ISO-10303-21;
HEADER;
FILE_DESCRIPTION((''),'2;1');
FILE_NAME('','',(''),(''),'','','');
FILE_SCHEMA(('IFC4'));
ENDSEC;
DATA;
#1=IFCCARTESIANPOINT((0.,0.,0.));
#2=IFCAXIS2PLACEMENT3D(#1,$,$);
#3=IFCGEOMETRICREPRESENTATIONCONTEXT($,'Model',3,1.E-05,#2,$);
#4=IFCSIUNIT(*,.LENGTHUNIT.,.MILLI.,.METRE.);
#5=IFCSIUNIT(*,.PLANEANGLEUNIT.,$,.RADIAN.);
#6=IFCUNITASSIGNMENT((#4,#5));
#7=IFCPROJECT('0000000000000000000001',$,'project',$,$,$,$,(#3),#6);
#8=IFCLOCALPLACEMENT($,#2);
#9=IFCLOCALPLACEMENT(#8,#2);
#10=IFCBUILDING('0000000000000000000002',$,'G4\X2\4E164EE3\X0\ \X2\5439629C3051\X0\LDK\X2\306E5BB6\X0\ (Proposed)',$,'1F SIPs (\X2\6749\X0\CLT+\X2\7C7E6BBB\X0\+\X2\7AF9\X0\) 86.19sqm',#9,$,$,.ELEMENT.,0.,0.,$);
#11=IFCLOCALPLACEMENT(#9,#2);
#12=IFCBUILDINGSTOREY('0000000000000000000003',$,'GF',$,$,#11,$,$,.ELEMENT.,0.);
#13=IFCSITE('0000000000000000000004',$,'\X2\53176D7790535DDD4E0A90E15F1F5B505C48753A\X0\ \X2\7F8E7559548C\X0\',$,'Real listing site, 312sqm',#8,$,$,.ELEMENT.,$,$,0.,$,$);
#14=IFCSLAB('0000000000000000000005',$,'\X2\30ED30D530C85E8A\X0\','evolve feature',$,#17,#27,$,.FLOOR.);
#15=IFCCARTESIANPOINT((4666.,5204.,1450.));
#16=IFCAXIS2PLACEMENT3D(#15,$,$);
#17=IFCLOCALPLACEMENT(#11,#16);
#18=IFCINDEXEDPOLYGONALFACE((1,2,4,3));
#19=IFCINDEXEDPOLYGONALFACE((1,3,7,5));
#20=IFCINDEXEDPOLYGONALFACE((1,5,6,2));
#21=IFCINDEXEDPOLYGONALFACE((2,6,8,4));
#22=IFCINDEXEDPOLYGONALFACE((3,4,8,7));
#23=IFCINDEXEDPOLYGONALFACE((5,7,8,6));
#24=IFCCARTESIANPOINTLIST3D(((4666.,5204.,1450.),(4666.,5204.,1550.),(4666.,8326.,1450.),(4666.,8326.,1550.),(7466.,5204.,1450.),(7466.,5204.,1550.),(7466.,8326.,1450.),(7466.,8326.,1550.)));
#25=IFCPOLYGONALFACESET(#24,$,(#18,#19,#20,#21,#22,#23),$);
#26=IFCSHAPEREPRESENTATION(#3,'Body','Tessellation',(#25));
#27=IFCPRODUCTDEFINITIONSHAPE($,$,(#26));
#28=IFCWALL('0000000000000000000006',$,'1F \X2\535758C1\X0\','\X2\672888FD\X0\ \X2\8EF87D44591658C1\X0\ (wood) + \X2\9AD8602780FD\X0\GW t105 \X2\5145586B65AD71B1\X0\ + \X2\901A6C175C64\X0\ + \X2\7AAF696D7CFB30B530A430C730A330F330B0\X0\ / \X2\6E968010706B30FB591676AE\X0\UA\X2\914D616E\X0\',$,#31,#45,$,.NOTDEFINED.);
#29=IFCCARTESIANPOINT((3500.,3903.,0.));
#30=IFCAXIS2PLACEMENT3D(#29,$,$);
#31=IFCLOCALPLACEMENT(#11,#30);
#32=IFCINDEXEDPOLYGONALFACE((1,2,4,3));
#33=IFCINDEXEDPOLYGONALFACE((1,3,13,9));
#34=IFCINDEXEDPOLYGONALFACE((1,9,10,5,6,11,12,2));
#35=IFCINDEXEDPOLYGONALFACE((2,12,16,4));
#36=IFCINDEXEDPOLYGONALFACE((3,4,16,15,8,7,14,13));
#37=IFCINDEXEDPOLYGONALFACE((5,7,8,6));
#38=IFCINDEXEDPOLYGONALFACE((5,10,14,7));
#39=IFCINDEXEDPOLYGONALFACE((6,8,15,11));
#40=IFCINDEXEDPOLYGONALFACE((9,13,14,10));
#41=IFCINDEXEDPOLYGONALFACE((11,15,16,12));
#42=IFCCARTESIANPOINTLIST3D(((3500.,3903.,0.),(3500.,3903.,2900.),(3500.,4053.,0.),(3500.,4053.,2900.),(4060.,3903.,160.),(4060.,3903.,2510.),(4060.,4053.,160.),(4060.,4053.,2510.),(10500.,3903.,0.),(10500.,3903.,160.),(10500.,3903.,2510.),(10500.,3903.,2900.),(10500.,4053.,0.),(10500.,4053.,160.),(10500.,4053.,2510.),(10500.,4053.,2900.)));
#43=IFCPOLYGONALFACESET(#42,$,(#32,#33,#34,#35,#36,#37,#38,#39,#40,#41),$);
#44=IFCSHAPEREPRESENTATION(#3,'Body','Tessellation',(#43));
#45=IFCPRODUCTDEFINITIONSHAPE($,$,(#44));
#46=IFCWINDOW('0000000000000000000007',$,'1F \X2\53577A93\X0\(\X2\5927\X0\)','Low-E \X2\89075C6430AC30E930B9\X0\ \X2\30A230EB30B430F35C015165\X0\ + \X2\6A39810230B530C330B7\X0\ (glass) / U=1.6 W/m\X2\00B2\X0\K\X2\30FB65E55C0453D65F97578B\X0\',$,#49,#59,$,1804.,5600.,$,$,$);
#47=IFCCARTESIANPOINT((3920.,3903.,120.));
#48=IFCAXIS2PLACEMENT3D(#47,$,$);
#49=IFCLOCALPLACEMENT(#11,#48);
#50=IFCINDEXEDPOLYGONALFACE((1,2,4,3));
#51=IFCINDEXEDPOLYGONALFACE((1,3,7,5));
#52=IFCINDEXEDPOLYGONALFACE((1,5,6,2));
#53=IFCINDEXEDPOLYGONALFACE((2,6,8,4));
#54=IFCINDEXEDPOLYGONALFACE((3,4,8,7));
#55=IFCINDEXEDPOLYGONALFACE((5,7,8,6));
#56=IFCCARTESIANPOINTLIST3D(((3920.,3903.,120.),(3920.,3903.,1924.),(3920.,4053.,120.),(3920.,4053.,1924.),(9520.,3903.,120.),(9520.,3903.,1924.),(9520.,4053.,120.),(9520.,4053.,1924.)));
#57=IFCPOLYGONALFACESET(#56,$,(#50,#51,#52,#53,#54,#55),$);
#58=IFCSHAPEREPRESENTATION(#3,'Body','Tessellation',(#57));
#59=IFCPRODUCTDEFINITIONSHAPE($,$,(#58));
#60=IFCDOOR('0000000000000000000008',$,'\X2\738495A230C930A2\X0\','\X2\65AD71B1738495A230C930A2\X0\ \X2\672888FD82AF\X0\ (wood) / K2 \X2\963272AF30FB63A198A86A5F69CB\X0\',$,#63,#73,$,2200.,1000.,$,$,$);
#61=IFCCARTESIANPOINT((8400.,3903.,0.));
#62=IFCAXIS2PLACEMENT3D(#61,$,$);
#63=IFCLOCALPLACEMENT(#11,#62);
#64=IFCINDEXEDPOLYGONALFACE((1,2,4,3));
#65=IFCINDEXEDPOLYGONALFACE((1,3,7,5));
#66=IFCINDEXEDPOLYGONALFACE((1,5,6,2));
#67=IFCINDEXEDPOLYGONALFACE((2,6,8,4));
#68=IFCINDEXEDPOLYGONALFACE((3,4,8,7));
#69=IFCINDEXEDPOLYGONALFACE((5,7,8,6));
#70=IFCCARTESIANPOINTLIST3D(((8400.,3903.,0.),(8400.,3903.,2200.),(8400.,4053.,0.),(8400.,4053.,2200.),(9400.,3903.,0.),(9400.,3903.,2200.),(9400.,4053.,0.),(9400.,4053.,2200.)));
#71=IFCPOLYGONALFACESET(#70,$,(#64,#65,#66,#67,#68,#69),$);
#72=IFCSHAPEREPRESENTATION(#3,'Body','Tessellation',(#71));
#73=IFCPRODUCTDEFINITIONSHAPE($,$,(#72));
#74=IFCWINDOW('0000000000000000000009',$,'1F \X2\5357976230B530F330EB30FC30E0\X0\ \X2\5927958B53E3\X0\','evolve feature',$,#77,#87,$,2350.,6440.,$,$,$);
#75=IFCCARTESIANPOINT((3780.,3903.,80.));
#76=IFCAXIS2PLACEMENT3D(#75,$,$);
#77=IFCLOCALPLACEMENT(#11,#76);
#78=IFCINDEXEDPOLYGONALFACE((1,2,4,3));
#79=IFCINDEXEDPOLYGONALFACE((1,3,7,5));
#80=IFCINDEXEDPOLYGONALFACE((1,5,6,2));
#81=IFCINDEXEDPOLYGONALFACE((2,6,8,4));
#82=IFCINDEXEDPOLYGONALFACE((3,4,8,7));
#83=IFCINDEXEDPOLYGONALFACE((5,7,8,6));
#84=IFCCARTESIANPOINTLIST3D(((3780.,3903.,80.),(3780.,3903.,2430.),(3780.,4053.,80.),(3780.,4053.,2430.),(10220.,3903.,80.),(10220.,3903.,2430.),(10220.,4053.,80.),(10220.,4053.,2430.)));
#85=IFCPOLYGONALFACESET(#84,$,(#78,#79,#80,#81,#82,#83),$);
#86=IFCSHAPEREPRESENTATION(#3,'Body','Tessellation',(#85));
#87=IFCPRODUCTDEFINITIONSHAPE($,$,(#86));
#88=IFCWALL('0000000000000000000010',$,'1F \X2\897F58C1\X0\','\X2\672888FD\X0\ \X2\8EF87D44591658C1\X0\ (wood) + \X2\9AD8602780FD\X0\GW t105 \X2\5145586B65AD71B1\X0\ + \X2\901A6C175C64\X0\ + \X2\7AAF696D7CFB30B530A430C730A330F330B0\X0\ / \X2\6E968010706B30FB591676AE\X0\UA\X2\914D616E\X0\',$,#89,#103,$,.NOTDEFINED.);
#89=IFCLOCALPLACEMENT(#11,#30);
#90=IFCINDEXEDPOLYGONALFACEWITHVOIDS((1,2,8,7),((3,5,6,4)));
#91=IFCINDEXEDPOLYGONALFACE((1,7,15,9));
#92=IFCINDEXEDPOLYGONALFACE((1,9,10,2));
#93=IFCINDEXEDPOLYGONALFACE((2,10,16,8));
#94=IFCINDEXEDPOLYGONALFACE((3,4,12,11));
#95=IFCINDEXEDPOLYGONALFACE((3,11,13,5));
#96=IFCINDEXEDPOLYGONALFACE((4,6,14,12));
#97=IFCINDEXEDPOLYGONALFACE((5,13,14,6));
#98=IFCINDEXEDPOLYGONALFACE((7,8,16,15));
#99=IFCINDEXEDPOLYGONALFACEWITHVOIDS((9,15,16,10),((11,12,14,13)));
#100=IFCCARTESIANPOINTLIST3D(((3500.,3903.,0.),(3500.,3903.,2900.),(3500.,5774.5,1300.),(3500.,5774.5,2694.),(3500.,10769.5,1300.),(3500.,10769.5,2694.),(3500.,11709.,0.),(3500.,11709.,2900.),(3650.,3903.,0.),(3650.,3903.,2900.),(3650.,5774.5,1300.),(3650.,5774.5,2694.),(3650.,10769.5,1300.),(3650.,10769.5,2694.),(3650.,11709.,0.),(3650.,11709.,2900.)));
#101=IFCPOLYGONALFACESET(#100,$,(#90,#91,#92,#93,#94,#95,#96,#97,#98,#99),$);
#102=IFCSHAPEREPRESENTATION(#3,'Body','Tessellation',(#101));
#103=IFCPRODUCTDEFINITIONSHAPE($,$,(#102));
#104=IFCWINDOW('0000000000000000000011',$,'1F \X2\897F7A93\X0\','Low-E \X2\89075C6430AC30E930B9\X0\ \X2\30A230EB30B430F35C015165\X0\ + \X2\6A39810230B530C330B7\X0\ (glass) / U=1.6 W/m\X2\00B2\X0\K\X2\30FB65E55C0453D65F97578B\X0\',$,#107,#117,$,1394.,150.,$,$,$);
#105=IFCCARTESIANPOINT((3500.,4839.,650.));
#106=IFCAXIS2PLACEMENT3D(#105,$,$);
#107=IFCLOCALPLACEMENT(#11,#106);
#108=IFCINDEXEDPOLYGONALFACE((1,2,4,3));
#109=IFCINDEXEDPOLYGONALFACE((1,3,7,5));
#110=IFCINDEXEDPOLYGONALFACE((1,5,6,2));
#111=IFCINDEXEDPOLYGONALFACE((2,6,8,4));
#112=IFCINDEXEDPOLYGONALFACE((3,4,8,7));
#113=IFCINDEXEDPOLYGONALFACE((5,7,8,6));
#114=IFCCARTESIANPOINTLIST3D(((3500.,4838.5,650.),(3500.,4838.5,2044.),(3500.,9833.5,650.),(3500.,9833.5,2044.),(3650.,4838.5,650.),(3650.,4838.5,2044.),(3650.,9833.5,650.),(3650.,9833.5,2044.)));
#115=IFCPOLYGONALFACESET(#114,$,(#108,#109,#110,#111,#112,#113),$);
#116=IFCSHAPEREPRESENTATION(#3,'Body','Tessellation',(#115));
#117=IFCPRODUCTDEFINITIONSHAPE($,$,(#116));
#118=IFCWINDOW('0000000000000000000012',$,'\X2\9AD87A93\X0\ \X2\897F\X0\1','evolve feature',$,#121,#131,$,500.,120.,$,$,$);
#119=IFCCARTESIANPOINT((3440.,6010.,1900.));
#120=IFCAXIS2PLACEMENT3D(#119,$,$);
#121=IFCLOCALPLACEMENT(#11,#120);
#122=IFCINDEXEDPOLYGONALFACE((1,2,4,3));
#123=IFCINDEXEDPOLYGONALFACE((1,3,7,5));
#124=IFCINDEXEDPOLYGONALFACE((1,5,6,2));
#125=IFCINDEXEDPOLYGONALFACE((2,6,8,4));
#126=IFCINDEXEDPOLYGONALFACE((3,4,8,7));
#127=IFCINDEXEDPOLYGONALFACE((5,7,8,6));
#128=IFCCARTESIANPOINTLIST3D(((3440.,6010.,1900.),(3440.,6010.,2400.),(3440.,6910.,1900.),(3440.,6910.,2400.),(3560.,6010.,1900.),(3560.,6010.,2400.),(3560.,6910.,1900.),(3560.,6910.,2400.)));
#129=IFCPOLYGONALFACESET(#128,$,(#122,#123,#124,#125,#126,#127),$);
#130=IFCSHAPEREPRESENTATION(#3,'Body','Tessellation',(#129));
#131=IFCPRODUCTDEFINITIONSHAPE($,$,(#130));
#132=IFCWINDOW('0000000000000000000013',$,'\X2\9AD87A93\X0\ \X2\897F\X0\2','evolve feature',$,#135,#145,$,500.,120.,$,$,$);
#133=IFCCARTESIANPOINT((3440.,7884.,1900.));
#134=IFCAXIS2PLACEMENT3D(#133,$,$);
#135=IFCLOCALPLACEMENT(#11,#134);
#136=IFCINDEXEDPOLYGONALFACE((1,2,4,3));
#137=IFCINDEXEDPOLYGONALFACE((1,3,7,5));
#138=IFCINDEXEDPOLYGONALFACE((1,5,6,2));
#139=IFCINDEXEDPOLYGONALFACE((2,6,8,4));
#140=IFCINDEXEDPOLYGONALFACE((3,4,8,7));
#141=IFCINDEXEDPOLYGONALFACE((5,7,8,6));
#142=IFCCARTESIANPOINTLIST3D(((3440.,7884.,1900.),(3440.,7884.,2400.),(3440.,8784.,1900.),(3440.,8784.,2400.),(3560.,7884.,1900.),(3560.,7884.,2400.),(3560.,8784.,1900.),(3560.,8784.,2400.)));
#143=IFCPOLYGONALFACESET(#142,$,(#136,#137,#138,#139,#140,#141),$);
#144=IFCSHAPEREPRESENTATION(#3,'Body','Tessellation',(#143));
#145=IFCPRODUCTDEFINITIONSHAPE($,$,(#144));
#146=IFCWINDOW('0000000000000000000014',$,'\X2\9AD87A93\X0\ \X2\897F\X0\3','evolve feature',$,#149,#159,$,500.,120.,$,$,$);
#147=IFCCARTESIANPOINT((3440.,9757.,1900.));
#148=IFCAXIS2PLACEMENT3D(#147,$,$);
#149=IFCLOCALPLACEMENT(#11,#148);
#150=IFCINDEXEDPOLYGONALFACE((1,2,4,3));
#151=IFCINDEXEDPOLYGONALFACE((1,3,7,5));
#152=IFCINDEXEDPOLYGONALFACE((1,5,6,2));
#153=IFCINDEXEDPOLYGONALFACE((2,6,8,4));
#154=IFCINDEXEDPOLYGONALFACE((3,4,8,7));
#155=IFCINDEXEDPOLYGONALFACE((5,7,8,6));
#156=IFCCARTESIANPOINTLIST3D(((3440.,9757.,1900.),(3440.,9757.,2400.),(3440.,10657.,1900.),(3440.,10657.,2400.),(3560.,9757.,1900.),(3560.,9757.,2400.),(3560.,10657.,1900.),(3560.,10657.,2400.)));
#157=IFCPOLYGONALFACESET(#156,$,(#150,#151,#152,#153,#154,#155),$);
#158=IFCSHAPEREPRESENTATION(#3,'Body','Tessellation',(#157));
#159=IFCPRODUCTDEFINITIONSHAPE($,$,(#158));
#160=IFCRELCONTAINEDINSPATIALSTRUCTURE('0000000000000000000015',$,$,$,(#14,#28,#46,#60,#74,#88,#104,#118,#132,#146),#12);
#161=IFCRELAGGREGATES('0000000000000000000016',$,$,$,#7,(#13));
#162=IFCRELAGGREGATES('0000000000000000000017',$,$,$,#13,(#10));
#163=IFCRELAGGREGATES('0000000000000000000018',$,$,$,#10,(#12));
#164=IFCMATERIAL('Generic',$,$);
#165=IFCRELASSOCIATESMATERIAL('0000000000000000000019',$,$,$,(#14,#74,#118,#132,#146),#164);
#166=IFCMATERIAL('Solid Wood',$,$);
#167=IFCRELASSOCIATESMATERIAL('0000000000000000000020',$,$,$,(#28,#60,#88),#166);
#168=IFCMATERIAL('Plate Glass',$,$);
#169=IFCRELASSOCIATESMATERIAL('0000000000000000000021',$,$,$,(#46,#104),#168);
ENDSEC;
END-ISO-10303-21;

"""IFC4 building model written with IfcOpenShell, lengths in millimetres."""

from ifc_helpers import new_model, si_unit, frame, frame_2d, origin, place, context, project, spatial, rectangle, extrude, material, element, fill, save


model = new_model("IFC4")

# Units and contexts
model_context = context("Model", 3, precision=1e-05, world=origin())
ifc_project = project(units=[si_unit("LENGTHUNIT", "METRE", prefix="MILLI"), si_unit("PLANEANGLEUNIT", "RADIAN")], contexts=[model_context])

# Site, building, storey
site_placement = place(None, origin())
site = spatial("IfcSite", under=ifc_project, at=site_placement, Name="北海道川上郡弟子屈町 美留和", ObjectType="Real listing site, 312sqm", CompositionType="ELEMENT", RefElevation=0.0)
building_placement = place(site_placement, origin())
building = spatial("IfcBuilding", under=site, at=building_placement, Name="G4世代 吹抜けLDKの家 (Proposed)", ObjectType="1F SIPs (杉CLT+籾殻+竹) 86.19sqm", CompositionType="ELEMENT", ElevationOfRefHeight=0.0, ElevationOfTerrain=0.0)
storey_placement = place(building_placement, origin())
storey = spatial("IfcBuildingStorey", under=building, at=storey_placement, Name="GF", CompositionType="ELEMENT", Elevation=0.0)

# Slab
ifc_material_1 = material(Name="Solid Wood")
ifc_material_2 = material(Name="Generic")
slab_1_placement = place(storey_placement, frame((4666.0, 5204.0, 1450.0)))
element("IfcSlab", 1, at=slab_1_placement, inside=storey, material=ifc_material_2, Name="ロフト床", Description="evolve feature", PredefinedType="FLOOR", context=model_context, shape_type="SweptSolid", body=[
    extrude(rectangle(XDim=2800.0, YDim=3122.0, at=frame_2d((1400.0, 1561.0))), frame((4666.0, 5204.0, 1450.0)), (0.0, 0.0, 1.0), 100.0),
])

# Wall, openings, windows, door
wall_1_placement = place(storey_placement, frame((3500.0, 3903.0, 0.0)))
wall_1 = element("IfcWall", 2, at=wall_1_placement, inside=storey, material=ifc_material_1, Name="1F 南壁", Description="木製 軸組外壁 (wood) + 高性能GW t105 充填断熱 + 通気層 + 窯業系サイディング / 準耐火・外皮UA配慮", PredefinedType="NOTDEFINED", context=model_context, shape_type="SweptSolid", body=[
    extrude(rectangle(XDim=7000.0, YDim=150.0, at=frame_2d((3500.0, 75.0))), frame((3500.0, 3903.0, 0.0)), (0.0, 0.0, 1.0), 2900.0),
])
opening_1_placement = place(storey_placement, frame((3920.0, 3903.0, 120.0)))
opening_1 = element("IfcOpeningElement", 3, at=opening_1_placement, cuts=wall_1, PredefinedType="NOTDEFINED", context=model_context, shape_type="SweptSolid", body=[
    extrude(rectangle(XDim=5600.0, YDim=150.0, at=frame_2d((2800.0, 75.0))), frame((3920.0, 3903.0, 120.0)), (0.0, 0.0, 1.0), 1804.0),
])
opening_2_placement = place(storey_placement, frame((8400.0, 3903.0, 0.0)))
opening_2 = element("IfcOpeningElement", 4, at=opening_2_placement, cuts=wall_1, PredefinedType="NOTDEFINED", context=model_context, shape_type="SweptSolid", body=[
    extrude(rectangle(XDim=1000.0, YDim=150.0, at=frame_2d((500.0, 75.0))), frame((8400.0, 3903.0, 0.0)), (0.0, 0.0, 1.0), 2200.0),
])
opening_3_placement = place(storey_placement, frame((3780.0, 3903.0, 80.0)))
opening_3 = element("IfcOpeningElement", 5, at=opening_3_placement, cuts=wall_1, PredefinedType="NOTDEFINED", context=model_context, shape_type="SweptSolid", body=[
    extrude(rectangle(XDim=6440.0, YDim=150.0, at=frame_2d((3220.0, 75.0))), frame((3780.0, 3903.0, 80.0)), (0.0, 0.0, 1.0), 2350.0),
])
ifc_material_3 = material(Name="Plate Glass")
window_1_placement = place(storey_placement, frame((3920.0, 3903.0, 120.0)))
window_1 = element("IfcWindow", 6, at=window_1_placement, inside=storey, material=ifc_material_3, Name="1F 南窓(大)", Description="Low-E 複層ガラス アルゴン封入 + 樹脂サッシ (glass) / U=1.6 W/m²K・日射取得型", OverallHeight=1804.0, OverallWidth=5600.0, context=model_context, shape_type="SweptSolid", body=[
    extrude(rectangle(XDim=5600.0, YDim=150.0, at=frame_2d((2800.0, 75.0))), frame((3920.0, 3903.0, 120.0)), (0.0, 0.0, 1.0), 1804.0),
])
fill(opening_1, window_1)
door_placement = place(storey_placement, frame((8400.0, 3903.0, 0.0)))
door = element("IfcDoor", 7, at=door_placement, inside=storey, material=ifc_material_1, Name="玄関ドア", Description="断熱玄関ドア 木製芯 (wood) / K2 防犯・採風機構", OverallHeight=2200.0, OverallWidth=1000.0, context=model_context, shape_type="SweptSolid", body=[
    extrude(rectangle(XDim=1000.0, YDim=150.0, at=frame_2d((500.0, 75.0))), frame((8400.0, 3903.0, 0.0)), (0.0, 0.0, 1.0), 2200.0),
])
fill(opening_2, door)
window_2_placement = place(storey_placement, frame((3780.0, 3903.0, 80.0)))
window_2 = element("IfcWindow", 8, at=window_2_placement, inside=storey, material=ifc_material_2, Name="1F 南面サンルーム 大開口", Description="evolve feature", OverallHeight=2350.0, OverallWidth=6440.0, context=model_context, shape_type="SweptSolid", body=[
    extrude(rectangle(XDim=6440.0, YDim=150.0, at=frame_2d((3220.0, 75.0))), frame((3780.0, 3903.0, 80.0)), (0.0, 0.0, 1.0), 2350.0),
])
fill(opening_3, window_2)

# Wall, openings, windows
wall_2_placement = place(storey_placement, frame((3500.0, 3903.0, 0.0)))
wall_2 = element("IfcWall", 9, at=wall_2_placement, inside=storey, material=ifc_material_1, Name="1F 西壁", Description="木製 軸組外壁 (wood) + 高性能GW t105 充填断熱 + 通気層 + 窯業系サイディング / 準耐火・外皮UA配慮", PredefinedType="NOTDEFINED", context=model_context, shape_type="SweptSolid", body=[
    extrude(rectangle(XDim=150.0, YDim=7806.0, at=frame_2d((75.0, 3903.0))), frame((3500.0, 3903.0, 0.0)), (0.0, 0.0, 1.0), 2900.0),
])
opening_4_placement = place(storey_placement, frame((3500.0, 4839.0, 650.0)))
opening_4 = element("IfcOpeningElement", 10, at=opening_4_placement, cuts=wall_2, PredefinedType="NOTDEFINED", context=model_context, shape_type="SweptSolid", body=[
    extrude(rectangle(XDim=150.0, YDim=4995.0, at=frame_2d((75.0, 2497.0))), frame((3500.0, 4839.0, 650.0)), (0.0, 0.0, 1.0), 1394.0),
])
opening_5_placement = place(storey_placement, frame((3440.0, 6010.0, 1900.0)))
opening_5 = element("IfcOpeningElement", 11, at=opening_5_placement, cuts=wall_2, PredefinedType="NOTDEFINED", context=model_context, shape_type="SweptSolid", body=[
    extrude(rectangle(XDim=120.0, YDim=900.0, at=frame_2d((60.0, 450.0))), frame((3440.0, 6010.0, 1900.0)), (0.0, 0.0, 1.0), 500.0),
])
opening_6_placement = place(storey_placement, frame((3440.0, 7884.0, 1900.0)))
opening_6 = element("IfcOpeningElement", 12, at=opening_6_placement, cuts=wall_2, PredefinedType="NOTDEFINED", context=model_context, shape_type="SweptSolid", body=[
    extrude(rectangle(XDim=120.0, YDim=900.0, at=frame_2d((60.0, 450.0))), frame((3440.0, 7884.0, 1900.0)), (0.0, 0.0, 1.0), 500.0),
])
opening_7_placement = place(storey_placement, frame((3440.0, 9757.0, 1900.0)))
opening_7 = element("IfcOpeningElement", 13, at=opening_7_placement, cuts=wall_2, PredefinedType="NOTDEFINED", context=model_context, shape_type="SweptSolid", body=[
    extrude(rectangle(XDim=120.0, YDim=900.0, at=frame_2d((60.0, 450.0))), frame((3440.0, 9757.0, 1900.0)), (0.0, 0.0, 1.0), 500.0),
])
window_3_placement = place(storey_placement, frame((3500.0, 4839.0, 650.0)))
window_3 = element("IfcWindow", 14, at=window_3_placement, inside=storey, material=ifc_material_3, Name="1F 西窓", Description="Low-E 複層ガラス アルゴン封入 + 樹脂サッシ (glass) / U=1.6 W/m²K・日射取得型", OverallHeight=1394.0, OverallWidth=150.0, context=model_context, shape_type="SweptSolid", body=[
    extrude(rectangle(XDim=150.0, YDim=4995.0, at=frame_2d((75.0, 2497.0))), frame((3500.0, 4839.0, 650.0)), (0.0, 0.0, 1.0), 1394.0),
])
fill(opening_4, window_3)
window_4_placement = place(storey_placement, frame((3440.0, 6010.0, 1900.0)))
window_4 = element("IfcWindow", 15, at=window_4_placement, inside=storey, material=ifc_material_2, Name="高窓 西1", Description="evolve feature", OverallHeight=500.0, OverallWidth=120.0, context=model_context, shape_type="SweptSolid", body=[
    extrude(rectangle(XDim=120.0, YDim=900.0, at=frame_2d((60.0, 450.0))), frame((3440.0, 6010.0, 1900.0)), (0.0, 0.0, 1.0), 500.0),
])
fill(opening_5, window_4)
window_5_placement = place(storey_placement, frame((3440.0, 7884.0, 1900.0)))
window_5 = element("IfcWindow", 16, at=window_5_placement, inside=storey, material=ifc_material_2, Name="高窓 西2", Description="evolve feature", OverallHeight=500.0, OverallWidth=120.0, context=model_context, shape_type="SweptSolid", body=[
    extrude(rectangle(XDim=120.0, YDim=900.0, at=frame_2d((60.0, 450.0))), frame((3440.0, 7884.0, 1900.0)), (0.0, 0.0, 1.0), 500.0),
])
fill(opening_6, window_5)
window_6_placement = place(storey_placement, frame((3440.0, 9757.0, 1900.0)))
window_6 = element("IfcWindow", 17, at=window_6_placement, inside=storey, material=ifc_material_2, Name="高窓 西3", Description="evolve feature", OverallHeight=500.0, OverallWidth=120.0, context=model_context, shape_type="SweptSolid", body=[
    extrude(rectangle(XDim=120.0, YDim=900.0, at=frame_2d((60.0, 450.0))), frame((3440.0, 9757.0, 1900.0)), (0.0, 0.0, 1.0), 500.0),
])
fill(opening_7, window_6)

save(model, "model.ifc")
